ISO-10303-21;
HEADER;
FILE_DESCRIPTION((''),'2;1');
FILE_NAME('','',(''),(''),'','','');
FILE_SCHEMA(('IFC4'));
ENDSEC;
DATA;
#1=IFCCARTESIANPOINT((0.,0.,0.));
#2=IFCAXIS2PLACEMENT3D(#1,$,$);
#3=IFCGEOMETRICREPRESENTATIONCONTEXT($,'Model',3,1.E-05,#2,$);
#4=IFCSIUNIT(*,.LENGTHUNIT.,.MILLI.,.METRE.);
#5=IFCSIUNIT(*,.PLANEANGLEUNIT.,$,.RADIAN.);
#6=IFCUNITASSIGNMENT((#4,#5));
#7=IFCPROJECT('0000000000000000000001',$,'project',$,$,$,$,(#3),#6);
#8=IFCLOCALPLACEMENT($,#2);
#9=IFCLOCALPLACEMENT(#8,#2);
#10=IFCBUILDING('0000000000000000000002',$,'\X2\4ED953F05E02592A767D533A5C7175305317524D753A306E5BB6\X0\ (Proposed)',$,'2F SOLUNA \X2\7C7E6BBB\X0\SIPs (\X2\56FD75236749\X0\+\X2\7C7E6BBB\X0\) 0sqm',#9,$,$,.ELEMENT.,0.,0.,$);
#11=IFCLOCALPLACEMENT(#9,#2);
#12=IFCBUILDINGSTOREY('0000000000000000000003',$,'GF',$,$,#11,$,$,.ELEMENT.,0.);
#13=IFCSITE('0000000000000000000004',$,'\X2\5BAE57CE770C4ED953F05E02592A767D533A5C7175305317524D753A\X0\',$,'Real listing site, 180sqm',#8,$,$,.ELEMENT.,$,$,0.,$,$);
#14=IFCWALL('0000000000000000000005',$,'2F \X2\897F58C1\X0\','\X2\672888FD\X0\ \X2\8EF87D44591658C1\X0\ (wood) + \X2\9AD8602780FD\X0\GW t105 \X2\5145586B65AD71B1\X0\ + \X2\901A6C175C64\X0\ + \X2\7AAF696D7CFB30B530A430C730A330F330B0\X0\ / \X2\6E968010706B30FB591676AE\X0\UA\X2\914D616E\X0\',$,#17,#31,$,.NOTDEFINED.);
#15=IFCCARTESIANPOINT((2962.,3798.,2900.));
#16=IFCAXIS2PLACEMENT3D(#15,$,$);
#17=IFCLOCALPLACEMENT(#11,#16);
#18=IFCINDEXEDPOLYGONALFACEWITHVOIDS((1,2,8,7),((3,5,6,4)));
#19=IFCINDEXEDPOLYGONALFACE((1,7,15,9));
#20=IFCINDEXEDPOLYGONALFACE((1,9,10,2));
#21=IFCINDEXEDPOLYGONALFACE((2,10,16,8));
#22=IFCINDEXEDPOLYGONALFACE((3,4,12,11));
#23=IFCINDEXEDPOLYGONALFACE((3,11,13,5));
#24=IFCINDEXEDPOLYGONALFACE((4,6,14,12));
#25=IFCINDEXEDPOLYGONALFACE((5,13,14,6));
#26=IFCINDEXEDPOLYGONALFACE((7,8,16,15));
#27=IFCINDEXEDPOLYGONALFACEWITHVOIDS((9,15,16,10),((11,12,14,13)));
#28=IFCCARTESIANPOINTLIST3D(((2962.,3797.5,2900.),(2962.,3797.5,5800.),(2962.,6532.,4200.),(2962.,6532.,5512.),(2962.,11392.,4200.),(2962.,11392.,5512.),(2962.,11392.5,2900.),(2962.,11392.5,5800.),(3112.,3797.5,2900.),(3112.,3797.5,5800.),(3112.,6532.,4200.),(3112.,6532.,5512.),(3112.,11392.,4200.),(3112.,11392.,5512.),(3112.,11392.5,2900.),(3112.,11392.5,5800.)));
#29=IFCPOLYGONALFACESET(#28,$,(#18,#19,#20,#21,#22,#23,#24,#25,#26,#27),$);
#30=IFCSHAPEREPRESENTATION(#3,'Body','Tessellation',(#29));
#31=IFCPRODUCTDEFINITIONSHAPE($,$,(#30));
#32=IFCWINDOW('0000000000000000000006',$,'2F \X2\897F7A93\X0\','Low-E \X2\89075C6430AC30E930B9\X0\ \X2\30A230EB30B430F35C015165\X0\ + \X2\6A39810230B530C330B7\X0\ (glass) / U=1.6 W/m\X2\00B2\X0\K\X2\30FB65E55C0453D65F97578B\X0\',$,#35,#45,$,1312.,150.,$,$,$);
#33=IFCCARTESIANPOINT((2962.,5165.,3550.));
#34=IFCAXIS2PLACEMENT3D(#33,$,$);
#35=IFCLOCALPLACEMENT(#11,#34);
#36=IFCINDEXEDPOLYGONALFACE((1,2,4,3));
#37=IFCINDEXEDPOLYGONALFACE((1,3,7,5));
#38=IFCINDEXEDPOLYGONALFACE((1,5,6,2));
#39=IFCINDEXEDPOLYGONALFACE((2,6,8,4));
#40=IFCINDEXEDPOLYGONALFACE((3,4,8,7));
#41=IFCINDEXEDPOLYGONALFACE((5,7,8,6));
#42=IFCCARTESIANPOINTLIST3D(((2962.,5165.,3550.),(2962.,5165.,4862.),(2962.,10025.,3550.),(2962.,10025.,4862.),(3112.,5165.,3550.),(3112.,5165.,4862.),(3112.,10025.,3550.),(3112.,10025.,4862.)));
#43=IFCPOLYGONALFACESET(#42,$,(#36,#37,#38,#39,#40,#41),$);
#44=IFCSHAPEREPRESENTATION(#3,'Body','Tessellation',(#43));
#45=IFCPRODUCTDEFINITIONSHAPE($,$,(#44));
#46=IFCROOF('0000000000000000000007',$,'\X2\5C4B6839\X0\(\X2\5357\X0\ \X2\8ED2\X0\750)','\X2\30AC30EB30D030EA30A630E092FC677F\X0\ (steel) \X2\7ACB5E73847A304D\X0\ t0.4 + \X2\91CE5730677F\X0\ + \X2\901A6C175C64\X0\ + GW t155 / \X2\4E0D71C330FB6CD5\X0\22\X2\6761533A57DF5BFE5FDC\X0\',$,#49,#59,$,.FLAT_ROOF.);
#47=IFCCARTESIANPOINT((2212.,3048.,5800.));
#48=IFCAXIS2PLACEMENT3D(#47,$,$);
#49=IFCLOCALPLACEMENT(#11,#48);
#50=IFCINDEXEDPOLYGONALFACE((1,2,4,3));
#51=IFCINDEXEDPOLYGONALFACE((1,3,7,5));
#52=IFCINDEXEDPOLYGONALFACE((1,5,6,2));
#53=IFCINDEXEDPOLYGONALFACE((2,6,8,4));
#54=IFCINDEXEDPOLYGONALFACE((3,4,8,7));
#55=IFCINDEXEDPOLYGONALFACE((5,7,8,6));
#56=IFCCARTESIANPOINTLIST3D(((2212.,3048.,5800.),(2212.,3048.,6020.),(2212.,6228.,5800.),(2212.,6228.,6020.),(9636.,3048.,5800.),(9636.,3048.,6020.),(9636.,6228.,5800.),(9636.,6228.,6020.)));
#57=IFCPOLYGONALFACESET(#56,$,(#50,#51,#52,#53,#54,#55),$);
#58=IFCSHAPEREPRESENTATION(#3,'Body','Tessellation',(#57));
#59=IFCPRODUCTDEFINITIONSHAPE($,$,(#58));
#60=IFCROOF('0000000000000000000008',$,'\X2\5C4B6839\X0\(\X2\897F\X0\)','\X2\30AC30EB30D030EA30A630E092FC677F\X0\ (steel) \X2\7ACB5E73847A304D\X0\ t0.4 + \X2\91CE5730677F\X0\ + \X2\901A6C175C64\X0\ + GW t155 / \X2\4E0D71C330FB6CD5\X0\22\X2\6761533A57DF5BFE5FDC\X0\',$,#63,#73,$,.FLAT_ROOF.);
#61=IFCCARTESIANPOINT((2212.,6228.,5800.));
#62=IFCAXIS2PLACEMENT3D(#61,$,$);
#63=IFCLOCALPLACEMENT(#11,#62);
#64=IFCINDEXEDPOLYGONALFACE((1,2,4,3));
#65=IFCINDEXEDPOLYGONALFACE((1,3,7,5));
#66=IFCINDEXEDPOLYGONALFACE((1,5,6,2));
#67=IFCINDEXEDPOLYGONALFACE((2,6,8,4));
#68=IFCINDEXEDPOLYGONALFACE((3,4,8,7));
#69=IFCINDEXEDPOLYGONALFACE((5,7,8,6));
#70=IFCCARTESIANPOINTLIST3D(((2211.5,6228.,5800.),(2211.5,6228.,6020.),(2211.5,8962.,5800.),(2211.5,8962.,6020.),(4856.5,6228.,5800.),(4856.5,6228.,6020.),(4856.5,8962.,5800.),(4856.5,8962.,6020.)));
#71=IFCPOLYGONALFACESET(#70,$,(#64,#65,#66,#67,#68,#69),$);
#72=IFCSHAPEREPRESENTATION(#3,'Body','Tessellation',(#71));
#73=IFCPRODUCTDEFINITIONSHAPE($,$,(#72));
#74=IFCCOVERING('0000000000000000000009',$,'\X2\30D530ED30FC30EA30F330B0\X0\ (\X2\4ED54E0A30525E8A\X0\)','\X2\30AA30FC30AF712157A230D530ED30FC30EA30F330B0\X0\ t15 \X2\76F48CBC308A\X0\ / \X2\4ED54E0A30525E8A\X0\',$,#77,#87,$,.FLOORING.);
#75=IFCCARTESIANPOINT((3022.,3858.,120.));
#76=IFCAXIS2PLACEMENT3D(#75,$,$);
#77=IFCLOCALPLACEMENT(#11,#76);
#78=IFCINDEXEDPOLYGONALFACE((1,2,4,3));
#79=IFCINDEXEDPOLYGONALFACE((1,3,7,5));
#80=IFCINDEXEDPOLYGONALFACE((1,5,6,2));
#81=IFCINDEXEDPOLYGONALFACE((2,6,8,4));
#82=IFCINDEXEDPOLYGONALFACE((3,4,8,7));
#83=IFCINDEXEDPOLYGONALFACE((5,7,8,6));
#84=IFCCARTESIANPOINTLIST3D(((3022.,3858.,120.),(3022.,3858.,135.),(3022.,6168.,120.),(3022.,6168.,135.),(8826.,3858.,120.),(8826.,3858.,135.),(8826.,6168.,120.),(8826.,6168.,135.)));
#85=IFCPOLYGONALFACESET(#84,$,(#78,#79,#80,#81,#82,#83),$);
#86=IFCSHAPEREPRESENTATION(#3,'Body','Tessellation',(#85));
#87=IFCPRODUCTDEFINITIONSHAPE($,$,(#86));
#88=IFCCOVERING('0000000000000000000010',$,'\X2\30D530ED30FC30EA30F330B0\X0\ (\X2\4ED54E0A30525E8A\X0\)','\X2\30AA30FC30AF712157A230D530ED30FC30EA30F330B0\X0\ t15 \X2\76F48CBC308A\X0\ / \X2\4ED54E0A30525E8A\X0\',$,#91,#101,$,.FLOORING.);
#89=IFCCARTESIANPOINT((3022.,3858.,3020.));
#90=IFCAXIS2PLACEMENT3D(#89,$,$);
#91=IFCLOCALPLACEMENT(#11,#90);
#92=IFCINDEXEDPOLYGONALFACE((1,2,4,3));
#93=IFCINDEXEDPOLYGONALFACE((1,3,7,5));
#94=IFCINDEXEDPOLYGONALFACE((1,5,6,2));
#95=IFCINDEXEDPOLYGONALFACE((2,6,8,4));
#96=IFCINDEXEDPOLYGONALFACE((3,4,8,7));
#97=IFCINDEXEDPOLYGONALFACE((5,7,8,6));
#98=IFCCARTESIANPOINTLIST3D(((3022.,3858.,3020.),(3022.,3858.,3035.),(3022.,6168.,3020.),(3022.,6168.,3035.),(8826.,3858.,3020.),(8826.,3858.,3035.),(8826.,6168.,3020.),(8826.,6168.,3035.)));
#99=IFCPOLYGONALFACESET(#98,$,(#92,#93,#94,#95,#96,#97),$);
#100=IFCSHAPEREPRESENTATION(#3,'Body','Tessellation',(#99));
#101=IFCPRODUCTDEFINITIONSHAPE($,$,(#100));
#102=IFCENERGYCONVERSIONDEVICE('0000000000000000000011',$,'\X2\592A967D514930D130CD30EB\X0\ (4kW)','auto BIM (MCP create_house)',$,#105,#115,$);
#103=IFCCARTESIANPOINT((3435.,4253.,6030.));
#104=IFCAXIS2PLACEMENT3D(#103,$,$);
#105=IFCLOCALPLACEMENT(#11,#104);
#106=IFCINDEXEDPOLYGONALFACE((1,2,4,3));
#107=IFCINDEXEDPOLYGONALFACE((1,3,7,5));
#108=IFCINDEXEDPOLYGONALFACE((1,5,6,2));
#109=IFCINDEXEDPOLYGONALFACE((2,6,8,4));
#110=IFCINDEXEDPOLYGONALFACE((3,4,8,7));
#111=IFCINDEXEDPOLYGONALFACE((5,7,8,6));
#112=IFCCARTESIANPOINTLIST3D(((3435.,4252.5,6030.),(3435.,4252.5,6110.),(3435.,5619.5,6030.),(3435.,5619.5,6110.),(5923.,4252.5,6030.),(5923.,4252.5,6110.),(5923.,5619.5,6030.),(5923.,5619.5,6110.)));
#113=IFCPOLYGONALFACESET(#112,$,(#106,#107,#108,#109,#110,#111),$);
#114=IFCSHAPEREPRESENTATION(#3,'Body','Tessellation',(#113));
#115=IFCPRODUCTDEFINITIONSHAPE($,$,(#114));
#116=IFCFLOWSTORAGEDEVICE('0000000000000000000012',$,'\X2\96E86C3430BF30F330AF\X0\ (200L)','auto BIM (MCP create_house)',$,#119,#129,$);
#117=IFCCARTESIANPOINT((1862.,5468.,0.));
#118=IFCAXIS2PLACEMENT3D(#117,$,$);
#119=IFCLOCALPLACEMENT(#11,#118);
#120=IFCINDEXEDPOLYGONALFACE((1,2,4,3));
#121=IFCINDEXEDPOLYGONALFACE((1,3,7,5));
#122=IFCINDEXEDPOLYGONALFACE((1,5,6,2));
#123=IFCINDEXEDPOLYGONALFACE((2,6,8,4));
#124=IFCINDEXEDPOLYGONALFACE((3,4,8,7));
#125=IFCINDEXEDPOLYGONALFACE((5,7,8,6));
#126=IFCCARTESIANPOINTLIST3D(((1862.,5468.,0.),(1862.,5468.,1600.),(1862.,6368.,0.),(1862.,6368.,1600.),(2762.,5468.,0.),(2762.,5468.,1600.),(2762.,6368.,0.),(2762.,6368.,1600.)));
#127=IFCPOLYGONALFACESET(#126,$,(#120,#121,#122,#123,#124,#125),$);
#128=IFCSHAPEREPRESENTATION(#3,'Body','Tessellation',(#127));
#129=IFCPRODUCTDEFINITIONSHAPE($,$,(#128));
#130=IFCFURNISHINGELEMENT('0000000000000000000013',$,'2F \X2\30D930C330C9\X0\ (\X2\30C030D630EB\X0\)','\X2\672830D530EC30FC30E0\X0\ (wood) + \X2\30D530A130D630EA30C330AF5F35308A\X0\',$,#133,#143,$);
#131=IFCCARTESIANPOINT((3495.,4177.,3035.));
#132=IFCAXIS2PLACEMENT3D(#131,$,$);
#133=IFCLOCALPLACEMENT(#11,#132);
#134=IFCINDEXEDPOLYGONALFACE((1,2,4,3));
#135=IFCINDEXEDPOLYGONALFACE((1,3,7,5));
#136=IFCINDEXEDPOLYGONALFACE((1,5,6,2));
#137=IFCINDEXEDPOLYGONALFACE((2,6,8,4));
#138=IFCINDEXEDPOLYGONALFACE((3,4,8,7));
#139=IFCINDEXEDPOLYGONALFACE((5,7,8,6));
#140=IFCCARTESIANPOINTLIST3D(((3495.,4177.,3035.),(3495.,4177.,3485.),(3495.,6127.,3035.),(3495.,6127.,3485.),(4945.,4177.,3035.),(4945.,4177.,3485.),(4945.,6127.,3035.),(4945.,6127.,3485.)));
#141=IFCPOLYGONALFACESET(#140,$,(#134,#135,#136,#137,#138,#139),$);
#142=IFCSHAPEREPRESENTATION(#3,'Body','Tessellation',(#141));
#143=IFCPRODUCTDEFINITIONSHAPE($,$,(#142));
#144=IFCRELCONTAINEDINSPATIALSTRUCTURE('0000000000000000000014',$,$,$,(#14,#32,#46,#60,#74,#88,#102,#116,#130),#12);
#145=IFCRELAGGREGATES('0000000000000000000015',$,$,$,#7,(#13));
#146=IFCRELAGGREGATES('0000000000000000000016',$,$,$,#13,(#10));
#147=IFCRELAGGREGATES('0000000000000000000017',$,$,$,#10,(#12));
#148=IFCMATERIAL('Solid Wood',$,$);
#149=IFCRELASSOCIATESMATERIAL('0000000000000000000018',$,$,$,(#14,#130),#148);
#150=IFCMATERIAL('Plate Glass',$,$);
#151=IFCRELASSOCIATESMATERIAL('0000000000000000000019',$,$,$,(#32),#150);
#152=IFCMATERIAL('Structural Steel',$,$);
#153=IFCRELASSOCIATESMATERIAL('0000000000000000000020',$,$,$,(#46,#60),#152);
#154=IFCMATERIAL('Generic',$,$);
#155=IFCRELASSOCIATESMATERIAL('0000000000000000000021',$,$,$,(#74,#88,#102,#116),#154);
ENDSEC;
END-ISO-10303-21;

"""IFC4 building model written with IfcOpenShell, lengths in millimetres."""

from ifc_helpers import new_model, si_unit, frame, frame_2d, origin, place, context, project, spatial, rectangle, extrude, material, element, fill, save


model = new_model("IFC4")

# Units and contexts
model_context = context("Model", 3, precision=1e-05, world=origin())
ifc_project = project(units=[si_unit("LENGTHUNIT", "METRE", prefix="MILLI"), si_unit("PLANEANGLEUNIT", "RADIAN")], contexts=[model_context])

# Site, building, storey
site_placement = place(None, origin())
site = spatial("IfcSite", under=ifc_project, at=site_placement, Name="宮城県仙台市太白区山田北前町", ObjectType="Real listing site, 180sqm", CompositionType="ELEMENT", RefElevation=0.0)
building_placement = place(site_placement, origin())
building = spatial("IfcBuilding", under=site, at=building_placement, Name="仙台市太白区山田北前町の家 (Proposed)", ObjectType="2F SOLUNA 籾殻SIPs (国産杉+籾殻) 0sqm", CompositionType="ELEMENT", ElevationOfRefHeight=0.0, ElevationOfTerrain=0.0)
storey_placement = place(building_placement, origin())
storey = spatial("IfcBuildingStorey", under=building, at=storey_placement, Name="GF", CompositionType="ELEMENT", Elevation=0.0)

# Shared definitions
ifc_material_1 = material(Name="Solid Wood")

# Shared definitions
ifc_material_2 = material(Name="Plate Glass")

# Wall, opening, window
wall_1_placement = place(storey_placement, frame((2962.0, 3798.0, 2900.0)))
wall_1 = element("IfcWall", 1, at=wall_1_placement, inside=storey, material=ifc_material_1, Name="2F 西壁", Description="木製 軸組外壁 (wood) + 高性能GW t105 充填断熱 + 通気層 + 窯業系サイディング / 準耐火・外皮UA配慮", PredefinedType="NOTDEFINED", context=model_context, shape_type="SweptSolid", body=[
    extrude(rectangle(XDim=150.0, YDim=7595.0, at=frame_2d((75.0, 3797.0))), frame((2962.0, 3798.0, 2900.0)), (0.0, 0.0, 1.0), 2900.0),
])
opening_1_placement = place(storey_placement, frame((2962.0, 5165.0, 3550.0)))
opening_1 = element("IfcOpeningElement", 2, at=opening_1_placement, cuts=wall_1, PredefinedType="NOTDEFINED", context=model_context, shape_type="SweptSolid", body=[
    extrude(rectangle(XDim=150.0, YDim=4860.0, at=frame_2d((75.0, 2430.0))), frame((2962.0, 5165.0, 3550.0)), (0.0, 0.0, 1.0), 1312.0),
])
window_1_placement = place(storey_placement, frame((2962.0, 5165.0, 3550.0)))
window_1 = element("IfcWindow", 3, at=window_1_placement, inside=storey, material=ifc_material_2, Name="2F 西窓", Description="Low-E 複層ガラス アルゴン封入 + 樹脂サッシ (glass) / U=1.6 W/m²K・日射取得型", OverallHeight=1312.0, OverallWidth=150.0, context=model_context, shape_type="SweptSolid", body=[
    extrude(rectangle(XDim=150.0, YDim=4860.0, at=frame_2d((75.0, 2430.0))), frame((2962.0, 5165.0, 3550.0)), (0.0, 0.0, 1.0), 1312.0),
])
fill(opening_1, window_1)

# Roofs
ifc_material_3 = material(Name="Structural Steel")
roof_1_placement = place(storey_placement, frame((2212.0, 3048.0, 5800.0)))
element("IfcRoof", 4, at=roof_1_placement, inside=storey, material=ifc_material_3, Name="屋根(南 軒750)", Description="ガルバリウム鋼板 (steel) 立平葺き t0.4 + 野地板 + 通気層 + GW t155 / 不燃・法22条区域対応", PredefinedType="FLAT_ROOF", context=model_context, shape_type="SweptSolid", body=[
    extrude(rectangle(XDim=7424.0, YDim=3180.0, at=frame_2d((3712.0, 1590.0))), frame((2212.0, 3048.0, 5800.0)), (0.0, 0.0, 1.0), 220.0),
])
roof_2_placement = place(storey_placement, frame((2212.0, 6228.0, 5800.0)))
element("IfcRoof", 5, at=roof_2_placement, inside=storey, material=ifc_material_3, Name="屋根(西)", Description="ガルバリウム鋼板 (steel) 立平葺き t0.4 + 野地板 + 通気層 + GW t155 / 不燃・法22条区域対応", PredefinedType="FLAT_ROOF", context=model_context, shape_type="SweptSolid", body=[
    extrude(rectangle(XDim=2645.0, YDim=2734.0, at=frame_2d((1322.0, 1367.0))), frame((2212.0, 6228.0, 5800.0)), (0.0, 0.0, 1.0), 220.0),
])

# Coverings
ifc_material_4 = material(Name="Generic")
covering_1_placement = place(storey_placement, frame((3022.0, 3858.0, 120.0)))
element("IfcCovering", 6, at=covering_1_placement, inside=storey, material=ifc_material_4, Name="フローリング (仕上げ床)", Description="オーク無垢フローリング t15 直貼り / 仕上げ床", PredefinedType="FLOORING", context=model_context, shape_type="SweptSolid", body=[
    extrude(rectangle(XDim=5804.0, YDim=2310.0, at=frame_2d((2902.0, 1155.0))), frame((3022.0, 3858.0, 120.0)), (0.0, 0.0, 1.0), 15.0),
])
covering_2_placement = place(storey_placement, frame((3022.0, 3858.0, 3020.0)))
element("IfcCovering", 7, at=covering_2_placement, inside=storey, material=ifc_material_4, Name="フローリング (仕上げ床)", Description="オーク無垢フローリング t15 直貼り / 仕上げ床", PredefinedType="FLOORING", context=model_context, shape_type="SweptSolid", body=[
    extrude(rectangle(XDim=5804.0, YDim=2310.0, at=frame_2d((2902.0, 1155.0))), frame((3022.0, 3858.0, 3020.0)), (0.0, 0.0, 1.0), 15.0),
])

# Energy conversion device
energy_conversion_device_placement = place(storey_placement, frame((3435.0, 4253.0, 6030.0)))
element("IfcEnergyConversionDevice", 8, at=energy_conversion_device_placement, inside=storey, material=ifc_material_4, Name="太陽光パネル (4kW)", Description="auto BIM (MCP create_house)", context=model_context, shape_type="SweptSolid", body=[
    extrude(rectangle(XDim=2488.0, YDim=1367.0, at=frame_2d((1244.0, 683.0))), frame((3435.0, 4253.0, 6030.0)), (0.0, 0.0, 1.0), 80.0),
])

# Flow storage device
flow_storage_device_placement = place(storey_placement, frame((1862.0, 5468.0, 0.0)))
element("IfcFlowStorageDevice", 9, at=flow_storage_device_placement, inside=storey, material=ifc_material_4, Name="雨水タンク (200L)", Description="auto BIM (MCP create_house)", context=model_context, shape_type="SweptSolid", body=[
    extrude(rectangle(XDim=900.0, YDim=900.0, at=frame_2d((450.0, 450.0))), frame((1862.0, 5468.0, 0.0)), (0.0, 0.0, 1.0), 1600.0),
])

# Furnishing element
furnishing_placement = place(storey_placement, frame((3495.0, 4177.0, 3035.0)))
element("IfcFurnishingElement", 10, at=furnishing_placement, inside=storey, material=ifc_material_1, Name="2F ベッド (ダブル)", Description="木フレーム (wood) + ファブリック張り", context=model_context, shape_type="SweptSolid", body=[
    extrude(rectangle(XDim=1450.0, YDim=1950.0, at=frame_2d((725.0, 975.0))), frame((3495.0, 4177.0, 3035.0)), (0.0, 0.0, 1.0), 450.0),
])

save(model, "model.ifc")
